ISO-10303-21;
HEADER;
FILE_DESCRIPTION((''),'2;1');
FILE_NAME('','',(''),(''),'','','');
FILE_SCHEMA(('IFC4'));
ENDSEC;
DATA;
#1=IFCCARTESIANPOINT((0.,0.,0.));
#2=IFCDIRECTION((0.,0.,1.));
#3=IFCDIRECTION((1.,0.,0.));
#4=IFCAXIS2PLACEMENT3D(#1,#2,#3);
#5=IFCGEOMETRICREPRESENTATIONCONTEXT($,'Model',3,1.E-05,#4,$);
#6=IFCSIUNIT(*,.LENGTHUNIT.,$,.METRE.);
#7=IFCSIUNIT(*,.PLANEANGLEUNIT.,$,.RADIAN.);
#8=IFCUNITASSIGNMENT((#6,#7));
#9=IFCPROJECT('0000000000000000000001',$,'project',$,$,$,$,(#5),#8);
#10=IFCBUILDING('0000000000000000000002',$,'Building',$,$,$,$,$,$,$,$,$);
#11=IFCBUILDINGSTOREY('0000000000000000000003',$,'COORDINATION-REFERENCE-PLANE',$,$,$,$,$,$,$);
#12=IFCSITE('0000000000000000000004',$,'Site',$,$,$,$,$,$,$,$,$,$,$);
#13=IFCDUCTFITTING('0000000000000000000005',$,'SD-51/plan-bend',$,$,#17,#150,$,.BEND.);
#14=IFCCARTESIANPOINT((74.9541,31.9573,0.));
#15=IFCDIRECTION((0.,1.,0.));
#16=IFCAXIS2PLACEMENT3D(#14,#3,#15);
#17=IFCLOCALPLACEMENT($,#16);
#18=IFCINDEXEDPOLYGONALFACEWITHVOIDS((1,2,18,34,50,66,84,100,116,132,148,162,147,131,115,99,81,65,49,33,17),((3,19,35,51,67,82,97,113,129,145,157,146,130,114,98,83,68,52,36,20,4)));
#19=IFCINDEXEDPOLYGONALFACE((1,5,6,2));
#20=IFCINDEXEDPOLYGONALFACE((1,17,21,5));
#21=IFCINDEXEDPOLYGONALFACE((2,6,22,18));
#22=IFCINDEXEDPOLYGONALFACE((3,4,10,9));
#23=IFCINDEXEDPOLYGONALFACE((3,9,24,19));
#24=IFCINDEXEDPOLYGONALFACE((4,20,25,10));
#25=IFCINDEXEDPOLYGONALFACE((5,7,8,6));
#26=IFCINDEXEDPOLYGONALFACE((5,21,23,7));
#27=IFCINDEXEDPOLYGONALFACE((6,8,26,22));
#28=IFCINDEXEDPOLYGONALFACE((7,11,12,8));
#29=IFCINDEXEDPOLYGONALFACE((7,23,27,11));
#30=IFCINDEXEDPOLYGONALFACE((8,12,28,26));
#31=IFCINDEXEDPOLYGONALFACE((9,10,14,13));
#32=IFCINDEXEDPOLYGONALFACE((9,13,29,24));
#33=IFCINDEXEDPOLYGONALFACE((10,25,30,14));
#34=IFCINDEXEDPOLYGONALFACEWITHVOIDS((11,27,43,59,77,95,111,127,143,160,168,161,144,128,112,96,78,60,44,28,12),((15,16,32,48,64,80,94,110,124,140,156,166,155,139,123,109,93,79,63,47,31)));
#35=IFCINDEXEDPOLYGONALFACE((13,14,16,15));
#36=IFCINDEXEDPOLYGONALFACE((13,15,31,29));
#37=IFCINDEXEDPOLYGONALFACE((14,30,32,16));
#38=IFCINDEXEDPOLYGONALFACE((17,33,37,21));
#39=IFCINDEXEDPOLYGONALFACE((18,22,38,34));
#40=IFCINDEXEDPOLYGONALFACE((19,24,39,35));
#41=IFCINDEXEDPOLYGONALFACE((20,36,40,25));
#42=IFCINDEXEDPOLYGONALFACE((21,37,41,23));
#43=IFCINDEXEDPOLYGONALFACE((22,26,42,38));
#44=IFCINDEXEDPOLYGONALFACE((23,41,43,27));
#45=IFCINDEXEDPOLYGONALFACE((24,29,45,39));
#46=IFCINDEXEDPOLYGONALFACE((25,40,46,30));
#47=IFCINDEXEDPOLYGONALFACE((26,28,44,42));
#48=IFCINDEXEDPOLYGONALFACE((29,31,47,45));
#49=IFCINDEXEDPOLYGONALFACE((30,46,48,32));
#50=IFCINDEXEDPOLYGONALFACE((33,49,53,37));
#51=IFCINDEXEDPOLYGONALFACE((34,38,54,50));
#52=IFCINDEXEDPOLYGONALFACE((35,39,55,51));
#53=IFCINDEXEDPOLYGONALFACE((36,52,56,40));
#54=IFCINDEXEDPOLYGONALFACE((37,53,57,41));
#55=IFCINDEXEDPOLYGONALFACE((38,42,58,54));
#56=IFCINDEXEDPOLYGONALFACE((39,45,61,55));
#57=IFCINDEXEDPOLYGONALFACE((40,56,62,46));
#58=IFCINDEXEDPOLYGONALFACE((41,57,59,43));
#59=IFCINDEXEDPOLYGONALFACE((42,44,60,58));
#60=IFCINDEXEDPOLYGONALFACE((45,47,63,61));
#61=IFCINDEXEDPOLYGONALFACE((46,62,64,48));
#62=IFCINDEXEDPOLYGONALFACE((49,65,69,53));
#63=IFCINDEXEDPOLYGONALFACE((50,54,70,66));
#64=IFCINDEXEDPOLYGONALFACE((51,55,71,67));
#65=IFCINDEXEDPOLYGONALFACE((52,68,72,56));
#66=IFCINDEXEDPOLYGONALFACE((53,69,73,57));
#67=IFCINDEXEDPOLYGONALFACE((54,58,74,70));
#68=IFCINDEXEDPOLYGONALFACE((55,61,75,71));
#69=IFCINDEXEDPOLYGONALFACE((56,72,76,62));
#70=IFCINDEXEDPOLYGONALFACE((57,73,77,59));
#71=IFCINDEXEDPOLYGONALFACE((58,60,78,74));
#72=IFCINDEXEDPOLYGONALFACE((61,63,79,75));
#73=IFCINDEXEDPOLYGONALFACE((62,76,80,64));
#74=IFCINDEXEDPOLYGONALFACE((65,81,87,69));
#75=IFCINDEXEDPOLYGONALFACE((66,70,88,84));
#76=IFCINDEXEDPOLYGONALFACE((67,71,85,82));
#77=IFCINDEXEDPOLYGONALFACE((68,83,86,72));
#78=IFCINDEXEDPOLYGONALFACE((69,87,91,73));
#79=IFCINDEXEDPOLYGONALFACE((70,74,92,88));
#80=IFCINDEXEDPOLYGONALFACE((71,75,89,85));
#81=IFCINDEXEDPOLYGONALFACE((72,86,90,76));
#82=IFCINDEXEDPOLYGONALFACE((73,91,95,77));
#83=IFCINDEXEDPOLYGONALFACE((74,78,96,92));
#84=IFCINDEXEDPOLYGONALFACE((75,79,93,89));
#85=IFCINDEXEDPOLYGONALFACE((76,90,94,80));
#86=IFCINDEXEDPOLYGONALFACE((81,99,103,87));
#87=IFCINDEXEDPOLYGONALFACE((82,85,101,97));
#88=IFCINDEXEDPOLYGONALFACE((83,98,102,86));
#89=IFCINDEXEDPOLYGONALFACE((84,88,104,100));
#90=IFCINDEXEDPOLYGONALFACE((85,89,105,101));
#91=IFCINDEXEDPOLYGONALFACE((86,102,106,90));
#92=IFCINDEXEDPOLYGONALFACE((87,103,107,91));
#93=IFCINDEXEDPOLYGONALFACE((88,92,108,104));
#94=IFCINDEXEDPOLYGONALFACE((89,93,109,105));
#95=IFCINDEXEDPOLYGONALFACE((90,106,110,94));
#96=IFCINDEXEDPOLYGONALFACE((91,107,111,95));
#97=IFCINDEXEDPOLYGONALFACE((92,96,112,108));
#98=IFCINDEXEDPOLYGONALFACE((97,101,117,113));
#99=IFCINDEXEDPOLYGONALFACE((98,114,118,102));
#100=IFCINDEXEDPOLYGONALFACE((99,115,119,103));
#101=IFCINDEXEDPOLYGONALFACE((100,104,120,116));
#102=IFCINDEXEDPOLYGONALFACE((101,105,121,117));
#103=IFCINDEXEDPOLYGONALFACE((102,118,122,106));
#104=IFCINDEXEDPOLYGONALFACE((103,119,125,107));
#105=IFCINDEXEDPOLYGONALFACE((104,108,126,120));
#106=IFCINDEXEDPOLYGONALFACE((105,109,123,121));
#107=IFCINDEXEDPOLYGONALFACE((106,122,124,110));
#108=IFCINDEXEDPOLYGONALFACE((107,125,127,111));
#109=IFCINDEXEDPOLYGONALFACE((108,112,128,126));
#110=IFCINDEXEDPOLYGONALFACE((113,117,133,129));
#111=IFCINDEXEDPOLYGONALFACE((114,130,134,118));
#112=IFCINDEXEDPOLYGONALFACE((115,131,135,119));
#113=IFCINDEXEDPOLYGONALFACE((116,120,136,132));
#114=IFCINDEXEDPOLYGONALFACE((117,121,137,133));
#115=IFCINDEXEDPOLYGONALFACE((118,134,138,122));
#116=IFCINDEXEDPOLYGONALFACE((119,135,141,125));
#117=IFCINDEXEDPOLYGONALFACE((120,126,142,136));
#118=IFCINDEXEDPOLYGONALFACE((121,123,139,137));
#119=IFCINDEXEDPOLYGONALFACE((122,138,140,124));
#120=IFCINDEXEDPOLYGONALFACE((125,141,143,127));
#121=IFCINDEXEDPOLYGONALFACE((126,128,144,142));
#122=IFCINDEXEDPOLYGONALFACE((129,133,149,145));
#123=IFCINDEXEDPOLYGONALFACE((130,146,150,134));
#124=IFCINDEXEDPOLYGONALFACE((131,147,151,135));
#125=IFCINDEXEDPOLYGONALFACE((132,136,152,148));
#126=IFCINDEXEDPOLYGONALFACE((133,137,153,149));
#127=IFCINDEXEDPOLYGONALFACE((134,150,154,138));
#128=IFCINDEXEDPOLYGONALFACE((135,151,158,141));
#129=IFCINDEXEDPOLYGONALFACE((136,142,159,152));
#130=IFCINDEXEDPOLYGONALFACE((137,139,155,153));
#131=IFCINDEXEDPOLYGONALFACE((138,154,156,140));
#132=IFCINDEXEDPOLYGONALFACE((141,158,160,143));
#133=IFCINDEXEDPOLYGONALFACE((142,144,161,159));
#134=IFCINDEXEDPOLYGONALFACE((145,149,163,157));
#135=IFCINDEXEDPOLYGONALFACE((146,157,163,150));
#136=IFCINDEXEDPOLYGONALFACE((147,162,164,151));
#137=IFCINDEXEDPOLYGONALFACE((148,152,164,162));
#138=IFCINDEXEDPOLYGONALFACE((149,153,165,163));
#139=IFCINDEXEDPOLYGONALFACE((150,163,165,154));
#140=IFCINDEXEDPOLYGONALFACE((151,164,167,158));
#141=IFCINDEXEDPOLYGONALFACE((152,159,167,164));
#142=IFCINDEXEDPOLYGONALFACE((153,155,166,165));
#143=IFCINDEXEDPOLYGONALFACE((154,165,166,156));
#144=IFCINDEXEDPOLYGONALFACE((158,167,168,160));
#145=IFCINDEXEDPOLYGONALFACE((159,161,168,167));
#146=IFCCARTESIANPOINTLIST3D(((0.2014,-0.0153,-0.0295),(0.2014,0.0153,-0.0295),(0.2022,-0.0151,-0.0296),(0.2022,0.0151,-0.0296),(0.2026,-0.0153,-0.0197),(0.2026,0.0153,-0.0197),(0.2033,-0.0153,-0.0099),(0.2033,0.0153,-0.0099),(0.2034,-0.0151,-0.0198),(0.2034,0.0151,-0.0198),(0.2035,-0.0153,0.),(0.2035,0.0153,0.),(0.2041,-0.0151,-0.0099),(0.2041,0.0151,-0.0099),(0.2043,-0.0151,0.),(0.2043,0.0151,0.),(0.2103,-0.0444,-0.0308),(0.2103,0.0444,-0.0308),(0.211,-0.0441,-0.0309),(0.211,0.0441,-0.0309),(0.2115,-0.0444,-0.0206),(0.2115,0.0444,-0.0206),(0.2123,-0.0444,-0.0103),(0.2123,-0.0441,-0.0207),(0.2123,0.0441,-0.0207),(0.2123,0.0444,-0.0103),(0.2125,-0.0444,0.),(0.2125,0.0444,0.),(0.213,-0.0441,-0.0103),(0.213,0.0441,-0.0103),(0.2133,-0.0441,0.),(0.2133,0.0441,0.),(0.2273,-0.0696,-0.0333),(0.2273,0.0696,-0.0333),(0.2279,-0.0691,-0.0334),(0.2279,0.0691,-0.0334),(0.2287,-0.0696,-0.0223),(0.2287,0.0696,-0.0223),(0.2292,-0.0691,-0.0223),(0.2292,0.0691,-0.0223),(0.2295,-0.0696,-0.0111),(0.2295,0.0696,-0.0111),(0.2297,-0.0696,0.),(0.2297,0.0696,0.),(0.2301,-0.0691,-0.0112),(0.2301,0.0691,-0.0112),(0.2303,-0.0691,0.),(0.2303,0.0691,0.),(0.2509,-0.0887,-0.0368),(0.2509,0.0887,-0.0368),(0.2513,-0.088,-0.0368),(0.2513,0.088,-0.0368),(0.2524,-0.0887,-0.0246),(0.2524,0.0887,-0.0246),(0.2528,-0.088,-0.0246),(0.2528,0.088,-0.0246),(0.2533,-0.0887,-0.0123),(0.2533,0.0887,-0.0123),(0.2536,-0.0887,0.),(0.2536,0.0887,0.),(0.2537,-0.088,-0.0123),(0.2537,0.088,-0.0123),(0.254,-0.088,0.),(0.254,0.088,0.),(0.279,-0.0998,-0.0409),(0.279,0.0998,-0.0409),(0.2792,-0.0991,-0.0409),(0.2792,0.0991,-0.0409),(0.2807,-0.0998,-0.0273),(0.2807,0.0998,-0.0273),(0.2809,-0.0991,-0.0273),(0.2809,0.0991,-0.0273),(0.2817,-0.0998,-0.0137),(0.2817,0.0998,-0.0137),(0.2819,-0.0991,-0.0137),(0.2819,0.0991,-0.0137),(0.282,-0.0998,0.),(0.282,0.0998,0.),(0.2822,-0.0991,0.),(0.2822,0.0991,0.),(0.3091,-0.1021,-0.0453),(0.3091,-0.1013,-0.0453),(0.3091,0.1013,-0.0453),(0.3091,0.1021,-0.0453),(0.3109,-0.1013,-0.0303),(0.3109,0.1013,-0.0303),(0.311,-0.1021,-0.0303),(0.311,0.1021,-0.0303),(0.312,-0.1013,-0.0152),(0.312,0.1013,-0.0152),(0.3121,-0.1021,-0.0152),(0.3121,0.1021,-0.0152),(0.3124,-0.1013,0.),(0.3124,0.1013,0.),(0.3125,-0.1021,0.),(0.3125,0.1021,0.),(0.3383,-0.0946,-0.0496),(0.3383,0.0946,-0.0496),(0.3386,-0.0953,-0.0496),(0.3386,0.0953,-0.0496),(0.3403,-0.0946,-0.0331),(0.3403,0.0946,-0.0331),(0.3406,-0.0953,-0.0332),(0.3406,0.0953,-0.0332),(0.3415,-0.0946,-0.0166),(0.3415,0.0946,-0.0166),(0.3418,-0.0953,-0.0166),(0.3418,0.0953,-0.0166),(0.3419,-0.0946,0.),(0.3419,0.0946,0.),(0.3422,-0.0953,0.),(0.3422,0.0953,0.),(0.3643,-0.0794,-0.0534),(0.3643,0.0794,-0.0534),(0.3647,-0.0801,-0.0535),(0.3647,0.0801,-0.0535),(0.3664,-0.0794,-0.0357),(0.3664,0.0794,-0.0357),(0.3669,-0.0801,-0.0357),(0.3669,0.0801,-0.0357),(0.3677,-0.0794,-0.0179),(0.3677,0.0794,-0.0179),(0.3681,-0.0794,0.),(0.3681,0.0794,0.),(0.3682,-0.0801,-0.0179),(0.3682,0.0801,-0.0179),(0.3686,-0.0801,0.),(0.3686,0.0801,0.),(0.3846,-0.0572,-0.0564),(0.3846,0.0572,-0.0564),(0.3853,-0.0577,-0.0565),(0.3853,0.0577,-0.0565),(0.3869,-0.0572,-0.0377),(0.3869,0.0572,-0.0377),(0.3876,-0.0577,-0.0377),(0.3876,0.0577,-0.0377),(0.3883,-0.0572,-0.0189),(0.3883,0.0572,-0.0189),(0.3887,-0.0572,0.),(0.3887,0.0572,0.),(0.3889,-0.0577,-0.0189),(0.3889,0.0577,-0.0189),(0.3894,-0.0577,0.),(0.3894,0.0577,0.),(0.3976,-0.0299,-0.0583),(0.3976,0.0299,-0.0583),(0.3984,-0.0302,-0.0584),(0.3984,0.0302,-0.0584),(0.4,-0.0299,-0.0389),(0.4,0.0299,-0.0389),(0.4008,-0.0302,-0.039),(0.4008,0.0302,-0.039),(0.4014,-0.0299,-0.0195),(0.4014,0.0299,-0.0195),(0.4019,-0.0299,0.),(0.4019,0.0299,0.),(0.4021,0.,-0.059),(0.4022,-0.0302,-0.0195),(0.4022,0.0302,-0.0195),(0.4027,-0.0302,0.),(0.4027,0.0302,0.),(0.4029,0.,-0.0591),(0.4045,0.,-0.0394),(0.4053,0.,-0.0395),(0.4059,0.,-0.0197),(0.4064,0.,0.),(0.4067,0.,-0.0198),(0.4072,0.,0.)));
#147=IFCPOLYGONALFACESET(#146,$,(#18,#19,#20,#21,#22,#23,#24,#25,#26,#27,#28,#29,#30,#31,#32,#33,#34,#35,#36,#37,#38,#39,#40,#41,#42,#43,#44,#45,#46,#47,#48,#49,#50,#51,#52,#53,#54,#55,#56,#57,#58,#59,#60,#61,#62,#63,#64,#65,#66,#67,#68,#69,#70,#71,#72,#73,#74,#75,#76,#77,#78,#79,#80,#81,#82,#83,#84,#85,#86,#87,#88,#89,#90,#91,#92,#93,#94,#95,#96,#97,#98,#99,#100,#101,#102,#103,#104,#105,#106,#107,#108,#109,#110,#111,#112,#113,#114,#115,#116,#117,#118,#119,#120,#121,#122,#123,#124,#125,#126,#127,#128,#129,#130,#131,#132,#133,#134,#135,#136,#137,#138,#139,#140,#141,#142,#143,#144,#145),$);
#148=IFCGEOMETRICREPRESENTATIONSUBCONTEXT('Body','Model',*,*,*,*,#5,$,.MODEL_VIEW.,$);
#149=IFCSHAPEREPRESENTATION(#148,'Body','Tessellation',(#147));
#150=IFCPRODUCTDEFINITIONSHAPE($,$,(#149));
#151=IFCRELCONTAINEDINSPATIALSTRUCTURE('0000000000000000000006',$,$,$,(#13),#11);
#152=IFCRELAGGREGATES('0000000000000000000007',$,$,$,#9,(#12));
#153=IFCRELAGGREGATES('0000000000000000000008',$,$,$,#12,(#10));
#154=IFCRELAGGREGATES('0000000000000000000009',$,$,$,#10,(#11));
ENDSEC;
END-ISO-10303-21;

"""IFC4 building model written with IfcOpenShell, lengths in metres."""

from ifc_helpers import new_model, entity, si_unit, frame, origin_with_axes, place, context, subcontext, project, spatial, element, save


model = new_model("IFC4")

# Units and contexts
model_context = context("Model", 3, precision=1e-05, world=origin_with_axes())
body_context_1 = subcontext(model_context, "Body", "Model", "MODEL_VIEW")
ifc_project = project(units=[si_unit("LENGTHUNIT", "METRE"), si_unit("PLANEANGLEUNIT", "RADIAN")], contexts=[model_context])

# Site, building, storey
site = spatial("IfcSite", under=ifc_project, Name="Site")
building = spatial("IfcBuilding", under=site, Name="Building")
storey = spatial("IfcBuildingStorey", under=building, Name="COORDINATION-REFERENCE-PLANE")

# Duct fitting
duct_fitting_1_placement = place(None, frame((74.9541, 31.9573, 0.0), z_axis=(1.0, 0.0, 0.0), x_axis=(0.0, 1.0, 0.0)))
element("IfcDuctFitting", 1, at=duct_fitting_1_placement, inside=storey, Name="SD-51/plan-bend", PredefinedType="BEND", context=body_context_1, shape_type="SweptSolid", body=[
    entity("IfcRevolvedAreaSolid", entity("IfcCircleHollowProfileDef", "AREA", None, entity("IfcAxis2Placement2D", entity("IfcCartesianPoint", [0.3048, 0.0])), 0.1024, 0.0008), entity("IfcAxis2Placement3D", entity("IfcCartesianPoint", [0.0, 0.0, 0.0]), entity("IfcDirection", [0.0, 0.0, 1.0]), entity("IfcDirection", [1.0, 0.0, 0.0])), entity("IfcAxis1Placement", entity("IfcCartesianPoint", [0.0, 0.0, 0.0]), entity("IfcDirection", [0.0, 1.0, 0.0])), 0.145576),
])

save(model, "model.ifc")
